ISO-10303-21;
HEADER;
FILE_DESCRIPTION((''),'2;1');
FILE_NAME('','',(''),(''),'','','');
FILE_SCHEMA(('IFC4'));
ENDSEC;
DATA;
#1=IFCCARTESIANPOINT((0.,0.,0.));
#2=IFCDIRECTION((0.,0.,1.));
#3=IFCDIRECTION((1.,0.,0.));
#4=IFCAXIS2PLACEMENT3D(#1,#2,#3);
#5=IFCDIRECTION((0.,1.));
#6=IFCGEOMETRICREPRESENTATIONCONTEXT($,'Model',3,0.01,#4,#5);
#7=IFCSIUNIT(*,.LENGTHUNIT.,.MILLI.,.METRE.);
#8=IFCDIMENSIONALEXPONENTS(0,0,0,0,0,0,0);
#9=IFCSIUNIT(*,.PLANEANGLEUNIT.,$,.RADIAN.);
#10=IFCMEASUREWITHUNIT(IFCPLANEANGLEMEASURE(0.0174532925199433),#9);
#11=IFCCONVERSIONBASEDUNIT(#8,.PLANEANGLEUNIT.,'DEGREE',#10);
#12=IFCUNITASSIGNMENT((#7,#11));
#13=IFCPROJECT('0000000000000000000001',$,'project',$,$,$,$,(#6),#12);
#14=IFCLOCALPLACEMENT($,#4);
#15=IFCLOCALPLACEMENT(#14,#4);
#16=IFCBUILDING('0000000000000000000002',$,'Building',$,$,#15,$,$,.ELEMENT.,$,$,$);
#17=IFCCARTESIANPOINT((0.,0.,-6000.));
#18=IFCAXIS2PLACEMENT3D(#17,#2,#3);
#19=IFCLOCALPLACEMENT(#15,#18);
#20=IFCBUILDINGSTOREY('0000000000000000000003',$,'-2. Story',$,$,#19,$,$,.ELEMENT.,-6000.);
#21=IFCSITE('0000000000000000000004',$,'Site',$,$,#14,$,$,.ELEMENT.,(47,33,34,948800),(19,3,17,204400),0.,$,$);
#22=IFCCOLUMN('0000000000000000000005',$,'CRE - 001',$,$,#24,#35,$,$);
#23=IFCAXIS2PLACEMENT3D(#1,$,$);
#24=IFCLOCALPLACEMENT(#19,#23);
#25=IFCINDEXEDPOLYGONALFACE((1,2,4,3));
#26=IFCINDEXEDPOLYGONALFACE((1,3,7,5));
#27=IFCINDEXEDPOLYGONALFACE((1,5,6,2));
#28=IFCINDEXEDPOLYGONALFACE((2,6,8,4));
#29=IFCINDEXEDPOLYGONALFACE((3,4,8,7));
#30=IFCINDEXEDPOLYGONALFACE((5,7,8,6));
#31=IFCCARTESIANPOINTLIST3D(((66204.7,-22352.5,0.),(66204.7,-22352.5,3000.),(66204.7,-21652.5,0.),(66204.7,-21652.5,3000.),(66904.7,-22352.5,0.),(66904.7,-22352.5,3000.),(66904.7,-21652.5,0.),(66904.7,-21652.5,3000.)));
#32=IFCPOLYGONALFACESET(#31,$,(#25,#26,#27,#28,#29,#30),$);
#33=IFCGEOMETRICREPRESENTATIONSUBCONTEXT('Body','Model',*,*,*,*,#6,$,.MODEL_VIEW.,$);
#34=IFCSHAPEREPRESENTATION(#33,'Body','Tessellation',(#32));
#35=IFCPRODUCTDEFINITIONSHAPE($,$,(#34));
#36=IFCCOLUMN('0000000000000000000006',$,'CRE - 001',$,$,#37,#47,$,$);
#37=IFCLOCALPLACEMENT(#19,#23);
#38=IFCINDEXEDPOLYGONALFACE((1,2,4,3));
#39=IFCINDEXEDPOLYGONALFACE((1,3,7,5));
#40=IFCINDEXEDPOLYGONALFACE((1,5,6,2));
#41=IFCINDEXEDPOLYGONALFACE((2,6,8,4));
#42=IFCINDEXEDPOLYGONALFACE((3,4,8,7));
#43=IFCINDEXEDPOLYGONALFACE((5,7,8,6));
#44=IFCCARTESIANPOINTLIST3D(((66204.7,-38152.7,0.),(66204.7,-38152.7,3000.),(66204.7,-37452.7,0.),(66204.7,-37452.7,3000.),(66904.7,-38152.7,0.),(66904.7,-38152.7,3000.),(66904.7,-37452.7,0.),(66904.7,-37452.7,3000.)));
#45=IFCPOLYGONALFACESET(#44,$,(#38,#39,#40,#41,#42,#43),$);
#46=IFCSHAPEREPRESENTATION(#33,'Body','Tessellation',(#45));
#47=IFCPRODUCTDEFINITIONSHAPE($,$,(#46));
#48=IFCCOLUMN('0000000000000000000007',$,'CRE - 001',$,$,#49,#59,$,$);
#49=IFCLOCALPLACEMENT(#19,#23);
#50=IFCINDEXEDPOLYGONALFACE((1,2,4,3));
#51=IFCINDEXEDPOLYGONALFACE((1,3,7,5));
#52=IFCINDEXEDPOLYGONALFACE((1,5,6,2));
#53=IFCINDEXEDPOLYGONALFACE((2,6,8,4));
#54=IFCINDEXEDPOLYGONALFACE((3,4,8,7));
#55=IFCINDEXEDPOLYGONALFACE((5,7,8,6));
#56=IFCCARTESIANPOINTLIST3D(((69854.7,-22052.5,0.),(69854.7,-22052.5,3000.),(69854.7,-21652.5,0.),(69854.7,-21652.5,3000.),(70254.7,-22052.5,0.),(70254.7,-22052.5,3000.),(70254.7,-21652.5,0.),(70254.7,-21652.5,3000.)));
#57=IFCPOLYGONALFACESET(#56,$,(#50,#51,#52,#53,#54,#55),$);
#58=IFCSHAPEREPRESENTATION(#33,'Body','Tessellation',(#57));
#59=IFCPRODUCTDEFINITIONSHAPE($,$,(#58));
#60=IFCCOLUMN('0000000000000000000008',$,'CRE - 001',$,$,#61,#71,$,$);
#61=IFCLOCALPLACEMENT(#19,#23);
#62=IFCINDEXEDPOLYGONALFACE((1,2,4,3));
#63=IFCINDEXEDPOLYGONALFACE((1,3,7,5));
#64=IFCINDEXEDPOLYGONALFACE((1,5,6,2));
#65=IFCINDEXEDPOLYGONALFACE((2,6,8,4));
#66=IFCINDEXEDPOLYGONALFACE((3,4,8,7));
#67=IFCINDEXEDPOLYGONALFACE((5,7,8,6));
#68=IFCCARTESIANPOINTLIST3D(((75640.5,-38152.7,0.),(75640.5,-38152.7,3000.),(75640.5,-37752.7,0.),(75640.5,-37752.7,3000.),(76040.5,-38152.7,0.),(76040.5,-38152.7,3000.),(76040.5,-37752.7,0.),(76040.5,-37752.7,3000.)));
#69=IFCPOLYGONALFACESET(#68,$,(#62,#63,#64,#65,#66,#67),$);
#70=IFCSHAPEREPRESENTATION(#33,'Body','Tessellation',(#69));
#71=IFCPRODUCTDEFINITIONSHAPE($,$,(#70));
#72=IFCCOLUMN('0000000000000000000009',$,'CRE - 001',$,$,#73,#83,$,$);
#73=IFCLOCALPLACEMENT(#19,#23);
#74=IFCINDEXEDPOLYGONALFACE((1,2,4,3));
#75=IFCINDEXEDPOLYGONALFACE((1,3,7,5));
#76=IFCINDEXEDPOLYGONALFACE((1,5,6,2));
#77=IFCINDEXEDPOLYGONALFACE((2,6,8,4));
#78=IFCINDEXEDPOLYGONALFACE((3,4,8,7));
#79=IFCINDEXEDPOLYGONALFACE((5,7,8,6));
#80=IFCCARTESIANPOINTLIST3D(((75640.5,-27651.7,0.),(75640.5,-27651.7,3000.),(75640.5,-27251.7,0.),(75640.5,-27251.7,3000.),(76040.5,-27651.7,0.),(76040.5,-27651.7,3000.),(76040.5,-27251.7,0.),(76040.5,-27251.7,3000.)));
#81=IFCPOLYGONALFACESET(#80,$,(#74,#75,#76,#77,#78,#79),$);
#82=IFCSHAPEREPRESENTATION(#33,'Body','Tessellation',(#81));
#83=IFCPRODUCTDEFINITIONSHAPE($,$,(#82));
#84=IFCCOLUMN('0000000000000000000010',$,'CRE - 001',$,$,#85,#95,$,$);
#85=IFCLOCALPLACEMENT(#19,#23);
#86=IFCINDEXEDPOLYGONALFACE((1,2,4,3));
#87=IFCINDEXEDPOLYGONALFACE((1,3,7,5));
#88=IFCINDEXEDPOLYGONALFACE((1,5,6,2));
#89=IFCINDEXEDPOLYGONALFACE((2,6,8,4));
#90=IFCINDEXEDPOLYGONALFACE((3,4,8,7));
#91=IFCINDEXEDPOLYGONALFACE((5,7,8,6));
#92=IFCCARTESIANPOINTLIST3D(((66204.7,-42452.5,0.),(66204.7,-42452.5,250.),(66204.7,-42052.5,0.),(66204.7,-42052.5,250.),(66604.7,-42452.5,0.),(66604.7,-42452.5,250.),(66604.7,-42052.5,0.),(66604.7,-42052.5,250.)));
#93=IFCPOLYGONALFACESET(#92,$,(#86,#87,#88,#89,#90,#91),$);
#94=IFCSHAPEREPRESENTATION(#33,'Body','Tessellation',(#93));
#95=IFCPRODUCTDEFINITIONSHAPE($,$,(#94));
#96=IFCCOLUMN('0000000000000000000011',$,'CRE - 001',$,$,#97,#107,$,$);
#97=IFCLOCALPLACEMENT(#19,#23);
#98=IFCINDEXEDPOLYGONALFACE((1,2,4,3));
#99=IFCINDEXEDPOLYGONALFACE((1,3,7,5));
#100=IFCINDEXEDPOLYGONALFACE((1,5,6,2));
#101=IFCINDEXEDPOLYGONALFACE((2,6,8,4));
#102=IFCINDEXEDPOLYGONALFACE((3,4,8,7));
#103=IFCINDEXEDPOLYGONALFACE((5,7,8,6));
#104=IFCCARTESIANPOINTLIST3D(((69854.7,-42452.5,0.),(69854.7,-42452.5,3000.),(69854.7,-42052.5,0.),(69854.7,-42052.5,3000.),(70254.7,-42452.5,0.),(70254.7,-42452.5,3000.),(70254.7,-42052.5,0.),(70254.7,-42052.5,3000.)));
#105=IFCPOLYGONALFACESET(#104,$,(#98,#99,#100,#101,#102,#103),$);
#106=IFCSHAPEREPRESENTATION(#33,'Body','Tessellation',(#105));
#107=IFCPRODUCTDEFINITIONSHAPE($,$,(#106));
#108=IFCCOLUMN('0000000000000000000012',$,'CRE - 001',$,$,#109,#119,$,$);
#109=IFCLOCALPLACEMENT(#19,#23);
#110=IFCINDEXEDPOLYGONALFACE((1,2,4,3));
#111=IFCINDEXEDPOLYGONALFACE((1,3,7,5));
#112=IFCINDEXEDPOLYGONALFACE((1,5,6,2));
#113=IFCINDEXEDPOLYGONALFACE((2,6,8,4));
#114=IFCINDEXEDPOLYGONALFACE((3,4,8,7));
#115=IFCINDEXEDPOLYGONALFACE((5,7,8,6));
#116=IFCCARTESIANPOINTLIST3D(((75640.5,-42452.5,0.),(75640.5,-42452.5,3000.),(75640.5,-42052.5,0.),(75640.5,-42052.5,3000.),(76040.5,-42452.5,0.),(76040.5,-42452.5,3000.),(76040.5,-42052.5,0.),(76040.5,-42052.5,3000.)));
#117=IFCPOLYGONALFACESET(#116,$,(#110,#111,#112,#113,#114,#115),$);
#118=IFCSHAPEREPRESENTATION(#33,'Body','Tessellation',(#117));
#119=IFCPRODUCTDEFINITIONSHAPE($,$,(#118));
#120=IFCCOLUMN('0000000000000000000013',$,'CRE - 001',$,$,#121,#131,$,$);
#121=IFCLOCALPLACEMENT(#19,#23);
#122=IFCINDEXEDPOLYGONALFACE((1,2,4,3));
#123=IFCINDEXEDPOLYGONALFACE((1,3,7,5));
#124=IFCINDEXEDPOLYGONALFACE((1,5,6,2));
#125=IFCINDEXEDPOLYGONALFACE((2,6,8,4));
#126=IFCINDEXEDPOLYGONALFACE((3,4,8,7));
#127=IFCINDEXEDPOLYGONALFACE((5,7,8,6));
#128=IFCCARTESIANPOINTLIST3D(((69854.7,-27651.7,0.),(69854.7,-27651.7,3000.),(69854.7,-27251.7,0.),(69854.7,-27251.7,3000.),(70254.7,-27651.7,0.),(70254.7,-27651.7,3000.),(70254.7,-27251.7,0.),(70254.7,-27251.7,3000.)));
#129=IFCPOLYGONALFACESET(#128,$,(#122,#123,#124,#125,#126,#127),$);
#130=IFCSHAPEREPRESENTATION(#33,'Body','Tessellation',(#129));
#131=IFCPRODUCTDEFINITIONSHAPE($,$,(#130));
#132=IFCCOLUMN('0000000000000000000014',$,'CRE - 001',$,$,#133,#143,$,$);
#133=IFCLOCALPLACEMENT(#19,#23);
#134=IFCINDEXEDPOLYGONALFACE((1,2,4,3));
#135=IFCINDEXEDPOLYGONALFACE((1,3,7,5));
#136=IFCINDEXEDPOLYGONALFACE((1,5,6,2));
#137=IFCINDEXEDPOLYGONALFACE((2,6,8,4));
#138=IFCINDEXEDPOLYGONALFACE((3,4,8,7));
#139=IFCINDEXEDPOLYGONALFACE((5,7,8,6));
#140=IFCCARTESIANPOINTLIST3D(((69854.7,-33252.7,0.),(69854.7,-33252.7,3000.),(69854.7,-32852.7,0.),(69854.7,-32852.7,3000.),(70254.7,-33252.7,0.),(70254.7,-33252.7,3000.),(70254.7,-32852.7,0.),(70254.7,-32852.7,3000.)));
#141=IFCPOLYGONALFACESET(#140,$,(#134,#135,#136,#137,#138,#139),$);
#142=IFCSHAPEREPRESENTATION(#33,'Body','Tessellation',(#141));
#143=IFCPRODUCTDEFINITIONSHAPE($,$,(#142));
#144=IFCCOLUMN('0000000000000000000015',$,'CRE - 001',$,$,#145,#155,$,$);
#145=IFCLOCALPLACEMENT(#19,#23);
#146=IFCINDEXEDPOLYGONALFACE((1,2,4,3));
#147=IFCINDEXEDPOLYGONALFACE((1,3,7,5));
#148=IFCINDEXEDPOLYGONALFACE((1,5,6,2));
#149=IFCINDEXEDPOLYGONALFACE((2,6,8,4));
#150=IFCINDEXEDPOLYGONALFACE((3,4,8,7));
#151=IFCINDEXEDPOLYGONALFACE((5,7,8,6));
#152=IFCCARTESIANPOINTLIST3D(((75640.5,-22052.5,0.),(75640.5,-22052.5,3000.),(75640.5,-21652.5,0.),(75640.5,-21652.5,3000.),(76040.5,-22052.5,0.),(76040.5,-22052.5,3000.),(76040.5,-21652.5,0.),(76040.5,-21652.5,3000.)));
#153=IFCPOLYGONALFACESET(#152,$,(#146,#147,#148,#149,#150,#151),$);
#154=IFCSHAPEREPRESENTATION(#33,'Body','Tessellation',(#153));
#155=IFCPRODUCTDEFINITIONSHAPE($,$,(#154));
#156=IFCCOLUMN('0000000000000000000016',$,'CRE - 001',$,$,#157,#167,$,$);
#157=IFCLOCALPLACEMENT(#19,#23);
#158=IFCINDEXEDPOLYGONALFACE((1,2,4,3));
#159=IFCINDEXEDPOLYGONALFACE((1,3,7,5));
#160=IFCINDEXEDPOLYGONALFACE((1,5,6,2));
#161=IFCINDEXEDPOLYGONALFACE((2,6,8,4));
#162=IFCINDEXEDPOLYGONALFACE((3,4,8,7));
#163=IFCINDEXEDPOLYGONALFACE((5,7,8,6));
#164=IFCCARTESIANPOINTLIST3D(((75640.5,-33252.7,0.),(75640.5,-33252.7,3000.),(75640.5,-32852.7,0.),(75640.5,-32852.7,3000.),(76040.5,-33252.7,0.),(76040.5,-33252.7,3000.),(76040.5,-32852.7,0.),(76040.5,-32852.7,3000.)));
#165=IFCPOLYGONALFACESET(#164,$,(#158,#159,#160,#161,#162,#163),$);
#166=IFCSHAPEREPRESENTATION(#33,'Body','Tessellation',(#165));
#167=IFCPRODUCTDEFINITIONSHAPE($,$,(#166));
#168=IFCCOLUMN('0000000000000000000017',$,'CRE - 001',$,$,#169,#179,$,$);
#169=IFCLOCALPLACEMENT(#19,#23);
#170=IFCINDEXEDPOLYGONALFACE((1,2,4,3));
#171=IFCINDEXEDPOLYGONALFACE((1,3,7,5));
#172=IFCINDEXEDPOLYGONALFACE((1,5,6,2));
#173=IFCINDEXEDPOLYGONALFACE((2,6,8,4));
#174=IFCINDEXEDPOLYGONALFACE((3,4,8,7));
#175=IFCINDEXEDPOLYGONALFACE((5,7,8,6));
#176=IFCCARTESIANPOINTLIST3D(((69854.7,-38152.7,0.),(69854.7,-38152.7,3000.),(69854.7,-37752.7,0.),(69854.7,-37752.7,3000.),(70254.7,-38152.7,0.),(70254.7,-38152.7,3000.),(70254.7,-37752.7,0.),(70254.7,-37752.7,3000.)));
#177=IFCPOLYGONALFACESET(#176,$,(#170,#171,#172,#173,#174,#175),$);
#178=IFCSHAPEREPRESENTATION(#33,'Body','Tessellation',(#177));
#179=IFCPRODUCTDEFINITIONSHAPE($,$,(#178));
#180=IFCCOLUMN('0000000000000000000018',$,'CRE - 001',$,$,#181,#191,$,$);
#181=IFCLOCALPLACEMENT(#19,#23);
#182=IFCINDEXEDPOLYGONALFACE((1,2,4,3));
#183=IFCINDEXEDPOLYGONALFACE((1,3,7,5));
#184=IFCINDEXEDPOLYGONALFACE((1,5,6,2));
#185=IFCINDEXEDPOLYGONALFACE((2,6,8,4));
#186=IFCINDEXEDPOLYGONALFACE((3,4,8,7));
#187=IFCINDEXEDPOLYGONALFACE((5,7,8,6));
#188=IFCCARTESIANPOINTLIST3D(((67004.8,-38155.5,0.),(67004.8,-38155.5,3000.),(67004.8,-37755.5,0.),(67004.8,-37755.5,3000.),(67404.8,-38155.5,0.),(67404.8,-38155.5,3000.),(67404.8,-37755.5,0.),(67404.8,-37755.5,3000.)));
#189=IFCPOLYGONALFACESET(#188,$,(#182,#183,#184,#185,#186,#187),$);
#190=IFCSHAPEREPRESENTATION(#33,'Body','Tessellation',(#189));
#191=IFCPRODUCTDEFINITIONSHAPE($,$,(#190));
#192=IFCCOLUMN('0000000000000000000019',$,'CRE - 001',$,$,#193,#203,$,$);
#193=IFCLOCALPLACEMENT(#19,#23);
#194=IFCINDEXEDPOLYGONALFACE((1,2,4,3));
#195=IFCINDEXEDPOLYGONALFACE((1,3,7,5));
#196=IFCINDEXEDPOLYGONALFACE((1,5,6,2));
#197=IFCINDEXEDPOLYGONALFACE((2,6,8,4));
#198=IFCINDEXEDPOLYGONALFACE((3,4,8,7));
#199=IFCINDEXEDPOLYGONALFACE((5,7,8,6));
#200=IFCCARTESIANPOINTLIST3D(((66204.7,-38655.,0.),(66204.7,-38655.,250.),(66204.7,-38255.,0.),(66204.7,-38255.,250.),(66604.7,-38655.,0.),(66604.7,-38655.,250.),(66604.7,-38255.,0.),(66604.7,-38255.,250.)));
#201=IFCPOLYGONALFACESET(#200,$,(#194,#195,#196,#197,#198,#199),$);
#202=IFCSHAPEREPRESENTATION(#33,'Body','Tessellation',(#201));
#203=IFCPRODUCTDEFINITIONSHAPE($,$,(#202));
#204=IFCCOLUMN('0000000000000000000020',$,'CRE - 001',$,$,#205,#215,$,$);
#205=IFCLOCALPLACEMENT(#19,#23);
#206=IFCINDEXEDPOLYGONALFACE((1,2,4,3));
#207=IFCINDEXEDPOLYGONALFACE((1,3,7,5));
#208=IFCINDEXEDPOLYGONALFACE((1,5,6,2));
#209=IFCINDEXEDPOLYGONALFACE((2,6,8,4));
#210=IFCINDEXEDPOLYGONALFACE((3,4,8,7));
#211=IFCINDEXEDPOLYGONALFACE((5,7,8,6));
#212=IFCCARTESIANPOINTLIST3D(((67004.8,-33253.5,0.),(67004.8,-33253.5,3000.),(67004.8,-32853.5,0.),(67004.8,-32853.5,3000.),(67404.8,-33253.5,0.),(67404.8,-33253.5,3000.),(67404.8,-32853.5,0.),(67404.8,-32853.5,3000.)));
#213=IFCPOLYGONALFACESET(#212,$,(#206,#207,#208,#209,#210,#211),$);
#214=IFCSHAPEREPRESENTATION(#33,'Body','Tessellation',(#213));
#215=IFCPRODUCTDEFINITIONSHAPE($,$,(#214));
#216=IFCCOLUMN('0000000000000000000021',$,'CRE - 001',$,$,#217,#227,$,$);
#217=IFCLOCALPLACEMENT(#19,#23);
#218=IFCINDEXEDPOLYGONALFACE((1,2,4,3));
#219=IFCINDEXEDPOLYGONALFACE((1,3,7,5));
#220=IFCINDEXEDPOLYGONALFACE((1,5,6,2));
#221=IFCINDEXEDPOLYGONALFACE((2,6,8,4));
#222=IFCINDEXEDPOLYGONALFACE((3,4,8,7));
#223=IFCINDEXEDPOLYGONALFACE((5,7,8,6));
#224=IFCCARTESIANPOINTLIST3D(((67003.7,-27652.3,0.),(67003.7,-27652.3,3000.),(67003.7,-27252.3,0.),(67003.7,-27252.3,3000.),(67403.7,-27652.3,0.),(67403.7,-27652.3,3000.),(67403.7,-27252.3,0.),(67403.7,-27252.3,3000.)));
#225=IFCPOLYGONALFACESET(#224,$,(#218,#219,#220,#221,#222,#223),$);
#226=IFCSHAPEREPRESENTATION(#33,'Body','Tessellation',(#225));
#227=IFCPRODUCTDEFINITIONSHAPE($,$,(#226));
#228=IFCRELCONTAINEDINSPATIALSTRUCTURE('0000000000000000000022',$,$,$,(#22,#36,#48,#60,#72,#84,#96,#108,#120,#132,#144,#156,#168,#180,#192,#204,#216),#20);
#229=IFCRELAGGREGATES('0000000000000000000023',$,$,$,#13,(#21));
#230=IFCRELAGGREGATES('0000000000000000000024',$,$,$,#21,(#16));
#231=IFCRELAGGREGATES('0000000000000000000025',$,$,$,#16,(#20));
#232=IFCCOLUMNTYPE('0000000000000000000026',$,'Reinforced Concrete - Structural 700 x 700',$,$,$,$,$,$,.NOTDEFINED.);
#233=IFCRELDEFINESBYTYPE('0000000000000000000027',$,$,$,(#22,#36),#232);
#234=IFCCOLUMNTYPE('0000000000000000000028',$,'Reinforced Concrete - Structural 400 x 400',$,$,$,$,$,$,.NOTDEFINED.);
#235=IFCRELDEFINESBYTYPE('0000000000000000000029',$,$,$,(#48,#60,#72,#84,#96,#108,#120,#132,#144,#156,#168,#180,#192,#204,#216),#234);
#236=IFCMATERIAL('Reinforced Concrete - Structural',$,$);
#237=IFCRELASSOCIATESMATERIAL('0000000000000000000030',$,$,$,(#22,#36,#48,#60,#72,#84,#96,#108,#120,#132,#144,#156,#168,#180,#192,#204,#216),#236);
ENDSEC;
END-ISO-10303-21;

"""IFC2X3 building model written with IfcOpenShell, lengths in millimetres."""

from ifc_helpers import new_model, entity, si_unit, converted_unit, direction, frame, origin_with_axes, origin_2d_with_axis, place, context, subcontext, project, spatial, rectangle, extrude, material, type_object, element, save


model = new_model("IFC2X3")

# Units and contexts
model_context = context("Model", 3, precision=0.01, world=origin_with_axes(), true_north=direction((0.0, 1.0)))
body_context = subcontext(model_context, "Body", "Model", "MODEL_VIEW")
ifc_project = project(units=[si_unit("LENGTHUNIT", "METRE", prefix="MILLI"), converted_unit("PLANEANGLEUNIT", "DEGREE", entity("IfcPlaneAngleMeasure", 0.0174532925199433), si_unit("PLANEANGLEUNIT", "RADIAN"), dimensions=[0, 0, 0, 0, 0, 0, 0])], contexts=[model_context])

# Site, building, storey
site_placement = place(None, origin_with_axes())
site = spatial("IfcSite", under=ifc_project, at=site_placement, Name="Site", CompositionType="ELEMENT", RefLatitude=(47, 33, 34, 948800), RefLongitude=(19, 3, 17, 204400), RefElevation=0.0)
building_placement = place(site_placement, origin_with_axes())
building = spatial("IfcBuilding", under=site, at=building_placement, Name="Building", CompositionType="ELEMENT")
storey_placement = place(building_placement, frame((0.0, 0.0, -6000.0), z_axis=(0.0, 0.0, 1.0), x_axis=(1.0, 0.0, 0.0)))
storey = spatial("IfcBuildingStorey", under=building, at=storey_placement, Name="-2. Story", CompositionType="ELEMENT", Elevation=-6000.0)

# Columns
ifc_material_1 = material(Name="Reinforced Concrete - Structural")
column_type_1 = type_object("IfcColumnType", Name="Reinforced Concrete - Structural 700 x 700", PredefinedType="NOTDEFINED")
for number, where, z_axis, x_axis, name in (
    (1, (66554.7, -22002.5, 0.0), (0.0, 0.0, 1.0), (1.0, 0.0, 0.0), "CRE - 001"),
    (2, (66554.7, -37802.7, 0.0), (0.0, 0.0, 1.0), (1.0, 0.0, 0.0), "CRE - 001"),
):
    element("IfcColumn", number, at=place(storey_placement, frame(where, z_axis=z_axis, x_axis=x_axis)), inside=storey, type_object=column_type_1, material=ifc_material_1, Name=name, context=body_context, shape_type="SweptSolid", body=[
        extrude(rectangle(XDim=700.0, YDim=700.0, at=origin_2d_with_axis()), origin_with_axes(), (0.0, 0.0, 1.0), 3000.0),
    ])
column_type_2 = type_object("IfcColumnType", Name="Reinforced Concrete - Structural 400 x 400", PredefinedType="NOTDEFINED")
for number, where, z_axis, x_axis, name in (
    (3, (70054.7, -21852.5, 0.0), (0.0, 0.0, 1.0), (1.0, 0.0, 0.0), "CRE - 001"),
    (4, (75840.5, -37952.7, 0.0), (0.0, 0.0, 1.0), (1.0, 0.0, 0.0), "CRE - 001"),
    (5, (75840.5, -27451.7, 0.0), (0.0, 0.0, 1.0), (1.0, 0.0, 0.0), "CRE - 001"),
):
    element("IfcColumn", number, at=place(storey_placement, frame(where, z_axis=z_axis, x_axis=x_axis)), inside=storey, type_object=column_type_2, material=ifc_material_1, Name=name, context=body_context, shape_type="SweptSolid", body=[
        extrude(rectangle(XDim=400.0, YDim=400.0, at=origin_2d_with_axis()), origin_with_axes(), (0.0, 0.0, 1.0), 3000.0),
    ])
column_1_placement = place(storey_placement, frame((66404.7, -42252.5, 0.0), z_axis=(0.0, 0.0, 1.0), x_axis=(1.0, 0.0, 0.0)))
element("IfcColumn", 6, at=column_1_placement, inside=storey, type_object=column_type_2, material=ifc_material_1, Name="CRE - 001", context=body_context, shape_type="SweptSolid", body=[
    extrude(rectangle(XDim=400.0, YDim=400.0, at=origin_2d_with_axis()), origin_with_axes(), (0.0, 0.0, 1.0), 250.0),
])
for number, where, z_axis, x_axis, name in (
    (7, (70054.7, -42252.5, 0.0), (0.0, 0.0, 1.0), (1.0, 0.0, 0.0), "CRE - 001"),
    (8, (75840.5, -42252.5, 0.0), (0.0, 0.0, 1.0), (1.0, 0.0, 0.0), "CRE - 001"),
    (9, (70054.7, -27451.7, 0.0), (0.0, 0.0, 1.0), (1.0, 0.0, 0.0), "CRE - 001"),
    (10, (70054.7, -33052.7, 0.0), (0.0, 0.0, 1.0), (1.0, 0.0, 0.0), "CRE - 001"),
    (11, (75840.5, -21852.5, 0.0), (0.0, 0.0, 1.0), (1.0, 0.0, 0.0), "CRE - 001"),
    (12, (75840.5, -33052.7, 0.0), (0.0, 0.0, 1.0), (1.0, 0.0, 0.0), "CRE - 001"),
    (13, (70054.7, -37952.7, 0.0), (0.0, 0.0, 1.0), (1.0, 0.0, 0.0), "CRE - 001"),
    (14, (67204.8, -37955.5, 0.0), (0.0, 0.0, 1.0), (1.0, 0.0, 0.0), "CRE - 001"),
):
    element("IfcColumn", number, at=place(storey_placement, frame(where, z_axis=z_axis, x_axis=x_axis)), inside=storey, type_object=column_type_2, material=ifc_material_1, Name=name, context=body_context, shape_type="SweptSolid", body=[
        extrude(rectangle(XDim=400.0, YDim=400.0, at=origin_2d_with_axis()), origin_with_axes(), (0.0, 0.0, 1.0), 3000.0),
    ])
column_2_placement = place(storey_placement, frame((66404.7, -38455.0, 0.0), z_axis=(0.0, 0.0, 1.0), x_axis=(1.0, 0.0, 0.0)))
element("IfcColumn", 15, at=column_2_placement, inside=storey, type_object=column_type_2, material=ifc_material_1, Name="CRE - 001", context=body_context, shape_type="SweptSolid", body=[
    extrude(rectangle(XDim=400.0, YDim=400.0, at=origin_2d_with_axis()), origin_with_axes(), (0.0, 0.0, 1.0), 250.0),
])
column_3_placement = place(storey_placement, frame((67204.8, -33053.5, 0.0), z_axis=(0.0, 0.0, 1.0), x_axis=(1.0, 0.0, 0.0)))
element("IfcColumn", 16, at=column_3_placement, inside=storey, type_object=column_type_2, material=ifc_material_1, Name="CRE - 001", context=body_context, shape_type="SweptSolid", body=[
    extrude(rectangle(XDim=400.0, YDim=400.0, at=origin_2d_with_axis()), origin_with_axes(), (0.0, 0.0, 1.0), 3000.0),
])
column_4_placement = place(storey_placement, frame((67203.7, -27452.3, 0.0), z_axis=(0.0, 0.0, 1.0), x_axis=(1.0, 0.0, 0.0)))
element("IfcColumn", 17, at=column_4_placement, inside=storey, type_object=column_type_2, material=ifc_material_1, Name="CRE - 001", context=body_context, shape_type="SweptSolid", body=[
    extrude(rectangle(XDim=400.0, YDim=400.0, at=origin_2d_with_axis()), origin_with_axes(), (0.0, 0.0, 1.0), 3000.0),
])

save(model, "model.ifc")
